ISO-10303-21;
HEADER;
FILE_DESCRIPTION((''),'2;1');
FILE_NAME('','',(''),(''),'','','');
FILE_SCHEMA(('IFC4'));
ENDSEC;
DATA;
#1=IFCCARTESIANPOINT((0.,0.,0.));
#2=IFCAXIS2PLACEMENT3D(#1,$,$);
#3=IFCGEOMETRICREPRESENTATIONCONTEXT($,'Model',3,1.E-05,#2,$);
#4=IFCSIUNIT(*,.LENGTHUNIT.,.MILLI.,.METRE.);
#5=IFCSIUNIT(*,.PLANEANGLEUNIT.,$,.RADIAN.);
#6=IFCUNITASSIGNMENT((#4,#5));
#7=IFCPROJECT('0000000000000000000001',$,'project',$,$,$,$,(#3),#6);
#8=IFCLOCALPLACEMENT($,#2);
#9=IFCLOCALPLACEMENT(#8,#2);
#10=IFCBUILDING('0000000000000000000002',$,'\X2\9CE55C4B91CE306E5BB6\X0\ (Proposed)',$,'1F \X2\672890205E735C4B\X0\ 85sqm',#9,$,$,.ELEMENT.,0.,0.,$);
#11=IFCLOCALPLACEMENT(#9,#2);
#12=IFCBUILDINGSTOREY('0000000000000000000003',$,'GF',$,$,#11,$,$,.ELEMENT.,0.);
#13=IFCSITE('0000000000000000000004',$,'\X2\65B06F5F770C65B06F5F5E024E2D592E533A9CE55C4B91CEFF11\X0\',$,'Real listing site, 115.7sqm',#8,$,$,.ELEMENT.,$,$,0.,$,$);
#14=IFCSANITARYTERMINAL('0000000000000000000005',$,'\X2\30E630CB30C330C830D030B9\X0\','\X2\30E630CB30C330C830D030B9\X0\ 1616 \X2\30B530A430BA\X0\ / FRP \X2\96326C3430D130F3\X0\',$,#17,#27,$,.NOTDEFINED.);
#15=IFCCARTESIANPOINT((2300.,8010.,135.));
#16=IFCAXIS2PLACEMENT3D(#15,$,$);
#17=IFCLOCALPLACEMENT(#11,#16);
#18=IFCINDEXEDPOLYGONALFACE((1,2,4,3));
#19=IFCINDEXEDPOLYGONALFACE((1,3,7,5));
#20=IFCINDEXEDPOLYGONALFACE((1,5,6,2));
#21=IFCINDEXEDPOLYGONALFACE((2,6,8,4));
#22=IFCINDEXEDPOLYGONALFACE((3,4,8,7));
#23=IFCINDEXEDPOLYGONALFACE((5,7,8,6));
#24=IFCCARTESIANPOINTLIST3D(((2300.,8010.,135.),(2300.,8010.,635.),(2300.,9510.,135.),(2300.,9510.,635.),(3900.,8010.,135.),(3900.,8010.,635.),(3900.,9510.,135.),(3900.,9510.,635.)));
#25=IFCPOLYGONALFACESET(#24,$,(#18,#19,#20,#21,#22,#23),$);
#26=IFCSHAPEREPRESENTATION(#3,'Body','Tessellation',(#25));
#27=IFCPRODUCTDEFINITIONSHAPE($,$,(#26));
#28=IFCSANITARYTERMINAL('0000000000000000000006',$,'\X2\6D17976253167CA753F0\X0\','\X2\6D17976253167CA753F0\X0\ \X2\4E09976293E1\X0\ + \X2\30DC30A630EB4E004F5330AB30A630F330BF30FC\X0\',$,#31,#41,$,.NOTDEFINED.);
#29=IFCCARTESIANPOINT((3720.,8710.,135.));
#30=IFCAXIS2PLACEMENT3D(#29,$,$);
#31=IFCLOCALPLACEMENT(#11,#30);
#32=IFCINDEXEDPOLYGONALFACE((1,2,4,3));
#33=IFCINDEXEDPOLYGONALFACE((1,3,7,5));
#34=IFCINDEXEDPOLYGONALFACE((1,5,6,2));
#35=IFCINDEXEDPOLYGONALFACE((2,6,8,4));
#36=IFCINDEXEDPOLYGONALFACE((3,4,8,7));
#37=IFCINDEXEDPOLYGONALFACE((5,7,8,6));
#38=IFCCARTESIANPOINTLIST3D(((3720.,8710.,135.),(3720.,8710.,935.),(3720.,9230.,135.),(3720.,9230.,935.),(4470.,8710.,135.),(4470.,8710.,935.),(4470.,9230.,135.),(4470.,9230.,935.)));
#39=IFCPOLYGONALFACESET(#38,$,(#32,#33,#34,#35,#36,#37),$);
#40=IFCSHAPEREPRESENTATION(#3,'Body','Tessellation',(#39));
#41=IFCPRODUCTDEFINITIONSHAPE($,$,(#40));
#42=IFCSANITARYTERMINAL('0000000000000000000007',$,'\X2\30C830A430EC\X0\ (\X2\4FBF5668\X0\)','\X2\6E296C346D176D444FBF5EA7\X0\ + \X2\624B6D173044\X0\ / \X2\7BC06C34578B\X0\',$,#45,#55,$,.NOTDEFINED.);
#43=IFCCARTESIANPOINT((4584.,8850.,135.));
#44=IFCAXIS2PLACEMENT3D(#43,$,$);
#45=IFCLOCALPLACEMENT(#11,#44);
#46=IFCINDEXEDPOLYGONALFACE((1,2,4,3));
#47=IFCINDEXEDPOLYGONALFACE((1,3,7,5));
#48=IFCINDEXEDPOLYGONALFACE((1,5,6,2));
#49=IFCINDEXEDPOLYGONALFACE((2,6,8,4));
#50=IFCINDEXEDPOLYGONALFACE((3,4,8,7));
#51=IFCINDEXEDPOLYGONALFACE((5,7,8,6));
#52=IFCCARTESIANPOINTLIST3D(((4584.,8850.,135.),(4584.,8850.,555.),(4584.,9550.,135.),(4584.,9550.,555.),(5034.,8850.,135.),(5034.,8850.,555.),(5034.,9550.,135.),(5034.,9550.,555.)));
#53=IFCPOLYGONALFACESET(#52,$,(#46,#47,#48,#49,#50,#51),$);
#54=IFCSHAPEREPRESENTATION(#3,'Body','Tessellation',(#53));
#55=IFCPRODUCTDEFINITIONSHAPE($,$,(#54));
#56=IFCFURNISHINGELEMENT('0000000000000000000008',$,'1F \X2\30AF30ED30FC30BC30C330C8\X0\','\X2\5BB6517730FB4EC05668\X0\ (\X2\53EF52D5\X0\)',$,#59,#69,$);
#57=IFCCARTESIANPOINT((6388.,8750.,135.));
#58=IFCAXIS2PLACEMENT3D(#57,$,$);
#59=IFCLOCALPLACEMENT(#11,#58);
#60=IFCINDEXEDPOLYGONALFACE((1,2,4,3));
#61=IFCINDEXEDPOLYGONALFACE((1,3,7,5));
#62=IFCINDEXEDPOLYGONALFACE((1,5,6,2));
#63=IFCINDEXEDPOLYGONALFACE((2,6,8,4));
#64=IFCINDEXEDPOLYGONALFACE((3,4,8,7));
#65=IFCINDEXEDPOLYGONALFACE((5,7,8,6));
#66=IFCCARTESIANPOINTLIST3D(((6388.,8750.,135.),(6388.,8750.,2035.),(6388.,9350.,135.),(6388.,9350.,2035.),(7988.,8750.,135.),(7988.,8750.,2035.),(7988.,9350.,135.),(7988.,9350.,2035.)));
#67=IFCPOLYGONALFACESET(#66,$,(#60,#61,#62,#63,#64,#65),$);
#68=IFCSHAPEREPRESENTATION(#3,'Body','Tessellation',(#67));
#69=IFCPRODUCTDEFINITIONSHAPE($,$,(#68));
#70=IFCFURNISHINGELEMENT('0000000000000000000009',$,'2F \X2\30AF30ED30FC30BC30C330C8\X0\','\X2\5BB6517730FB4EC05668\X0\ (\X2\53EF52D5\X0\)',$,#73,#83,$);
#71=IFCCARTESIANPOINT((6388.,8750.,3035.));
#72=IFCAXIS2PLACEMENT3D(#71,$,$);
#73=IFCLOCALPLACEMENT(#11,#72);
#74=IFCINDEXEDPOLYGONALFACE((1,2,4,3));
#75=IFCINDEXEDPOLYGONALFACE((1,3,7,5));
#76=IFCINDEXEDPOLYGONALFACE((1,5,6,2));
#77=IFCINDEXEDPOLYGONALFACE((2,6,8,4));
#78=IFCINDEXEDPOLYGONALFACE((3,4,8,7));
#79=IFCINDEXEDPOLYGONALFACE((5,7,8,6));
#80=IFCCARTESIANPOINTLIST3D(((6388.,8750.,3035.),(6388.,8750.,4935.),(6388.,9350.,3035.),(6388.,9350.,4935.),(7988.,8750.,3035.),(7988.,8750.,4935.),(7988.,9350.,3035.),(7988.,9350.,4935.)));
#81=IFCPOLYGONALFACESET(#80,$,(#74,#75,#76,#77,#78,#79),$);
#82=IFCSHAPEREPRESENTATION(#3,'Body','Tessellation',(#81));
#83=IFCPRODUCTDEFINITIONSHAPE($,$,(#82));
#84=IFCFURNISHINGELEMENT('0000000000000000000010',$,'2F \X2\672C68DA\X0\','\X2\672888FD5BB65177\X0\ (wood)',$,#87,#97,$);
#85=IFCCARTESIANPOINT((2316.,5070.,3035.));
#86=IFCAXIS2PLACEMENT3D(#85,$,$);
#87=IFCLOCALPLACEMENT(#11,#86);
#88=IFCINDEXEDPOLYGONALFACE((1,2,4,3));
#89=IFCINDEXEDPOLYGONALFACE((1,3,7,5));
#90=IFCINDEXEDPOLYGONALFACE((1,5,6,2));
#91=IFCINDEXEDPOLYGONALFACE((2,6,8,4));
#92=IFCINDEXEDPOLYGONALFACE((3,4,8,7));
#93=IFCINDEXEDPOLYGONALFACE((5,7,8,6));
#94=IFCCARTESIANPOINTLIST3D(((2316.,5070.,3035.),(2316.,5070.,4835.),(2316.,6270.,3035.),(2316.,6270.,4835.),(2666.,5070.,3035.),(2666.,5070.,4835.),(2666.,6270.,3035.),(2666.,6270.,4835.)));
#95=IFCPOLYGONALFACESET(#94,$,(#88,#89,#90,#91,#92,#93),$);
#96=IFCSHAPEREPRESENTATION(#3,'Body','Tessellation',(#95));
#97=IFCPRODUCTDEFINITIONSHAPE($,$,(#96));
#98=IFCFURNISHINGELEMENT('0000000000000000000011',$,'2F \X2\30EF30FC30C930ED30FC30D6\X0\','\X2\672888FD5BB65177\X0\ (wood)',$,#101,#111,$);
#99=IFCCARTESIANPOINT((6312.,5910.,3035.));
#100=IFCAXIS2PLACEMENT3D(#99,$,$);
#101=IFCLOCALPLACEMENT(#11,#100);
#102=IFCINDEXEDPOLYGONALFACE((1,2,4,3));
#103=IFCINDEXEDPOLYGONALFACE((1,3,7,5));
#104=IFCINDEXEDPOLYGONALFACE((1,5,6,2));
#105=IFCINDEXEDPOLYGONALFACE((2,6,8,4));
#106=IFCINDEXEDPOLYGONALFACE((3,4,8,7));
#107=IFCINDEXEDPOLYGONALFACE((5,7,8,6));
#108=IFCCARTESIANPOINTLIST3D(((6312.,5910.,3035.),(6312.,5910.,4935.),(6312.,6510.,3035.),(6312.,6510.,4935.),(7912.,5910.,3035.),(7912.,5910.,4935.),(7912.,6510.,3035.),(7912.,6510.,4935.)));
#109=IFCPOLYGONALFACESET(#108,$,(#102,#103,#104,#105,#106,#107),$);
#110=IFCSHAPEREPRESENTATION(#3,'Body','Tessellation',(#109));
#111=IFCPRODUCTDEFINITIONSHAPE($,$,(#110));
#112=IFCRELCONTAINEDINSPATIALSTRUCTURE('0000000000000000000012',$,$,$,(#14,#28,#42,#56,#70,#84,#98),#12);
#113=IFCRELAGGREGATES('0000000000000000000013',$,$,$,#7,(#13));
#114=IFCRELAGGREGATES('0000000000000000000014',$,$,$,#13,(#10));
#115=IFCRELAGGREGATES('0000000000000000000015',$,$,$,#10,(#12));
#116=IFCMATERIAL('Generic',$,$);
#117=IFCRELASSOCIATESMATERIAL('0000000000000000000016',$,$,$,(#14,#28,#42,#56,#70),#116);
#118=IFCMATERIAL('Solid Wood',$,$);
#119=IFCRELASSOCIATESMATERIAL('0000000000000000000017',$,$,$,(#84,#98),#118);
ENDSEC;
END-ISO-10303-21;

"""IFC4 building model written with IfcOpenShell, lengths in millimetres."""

from ifc_helpers import new_model, si_unit, frame, frame_2d, origin, place, context, project, spatial, rectangle, extrude, material, element, save


model = new_model("IFC4")

# Units and contexts
model_context = context("Model", 3, precision=1e-05, world=origin())
ifc_project = project(units=[si_unit("LENGTHUNIT", "METRE", prefix="MILLI"), si_unit("PLANEANGLEUNIT", "RADIAN")], contexts=[model_context])

# Site, building, storey
site_placement = place(None, origin())
site = spatial("IfcSite", under=ifc_project, at=site_placement, Name="新潟県新潟市中央区鳥屋野１", ObjectType="Real listing site, 115.7sqm", CompositionType="ELEMENT", RefElevation=0.0)
building_placement = place(site_placement, origin())
building = spatial("IfcBuilding", under=site, at=building_placement, Name="鳥屋野の家 (Proposed)", ObjectType="1F 木造平屋 85sqm", CompositionType="ELEMENT", ElevationOfRefHeight=0.0, ElevationOfTerrain=0.0)
storey_placement = place(building_placement, origin())
storey = spatial("IfcBuildingStorey", under=building, at=storey_placement, Name="GF", CompositionType="ELEMENT", Elevation=0.0)

# Shared definitions
ifc_material_1 = material(Name="Solid Wood")

# Shared definitions
ifc_material_2 = material(Name="Generic")

# Sanitary terminals
sanitary_terminal_1_placement = place(storey_placement, frame((2300.0, 8010.0, 135.0)))
element("IfcSanitaryTerminal", 1, at=sanitary_terminal_1_placement, inside=storey, material=ifc_material_2, Name="ユニットバス", Description="ユニットバス 1616 サイズ / FRP 防水パン", PredefinedType="NOTDEFINED", context=model_context, shape_type="SweptSolid", body=[
    extrude(rectangle(XDim=1600.0, YDim=1500.0, at=frame_2d((800.0, 750.0))), frame((2300.0, 8010.0, 135.0)), (0.0, 0.0, 1.0), 500.0),
])
sanitary_terminal_2_placement = place(storey_placement, frame((3720.0, 8710.0, 135.0)))
element("IfcSanitaryTerminal", 2, at=sanitary_terminal_2_placement, inside=storey, material=ifc_material_2, Name="洗面化粧台", Description="洗面化粧台 三面鏡 + ボウル一体カウンター", PredefinedType="NOTDEFINED", context=model_context, shape_type="SweptSolid", body=[
    extrude(rectangle(XDim=750.0, YDim=520.0, at=frame_2d((375.0, 260.0))), frame((3720.0, 8710.0, 135.0)), (0.0, 0.0, 1.0), 800.0),
])
sanitary_terminal_3_placement = place(storey_placement, frame((4584.0, 8850.0, 135.0)))
element("IfcSanitaryTerminal", 3, at=sanitary_terminal_3_placement, inside=storey, material=ifc_material_2, Name="トイレ (便器)", Description="温水洗浄便座 + 手洗い / 節水型", PredefinedType="NOTDEFINED", context=model_context, shape_type="SweptSolid", body=[
    extrude(rectangle(XDim=450.0, YDim=700.0, at=frame_2d((225.0, 350.0))), frame((4584.0, 8850.0, 135.0)), (0.0, 0.0, 1.0), 420.0),
])

# Furnishing elements
furnishing_1_placement = place(storey_placement, frame((6388.0, 8750.0, 135.0)))
element("IfcFurnishingElement", 4, at=furnishing_1_placement, inside=storey, material=ifc_material_2, Name="1F クローゼット", Description="家具・什器 (可動)", context=model_context, shape_type="SweptSolid", body=[
    extrude(rectangle(XDim=1600.0, YDim=600.0, at=frame_2d((800.0, 300.0))), frame((6388.0, 8750.0, 135.0)), (0.0, 0.0, 1.0), 1900.0),
])
furnishing_2_placement = place(storey_placement, frame((6388.0, 8750.0, 3035.0)))
element("IfcFurnishingElement", 5, at=furnishing_2_placement, inside=storey, material=ifc_material_2, Name="2F クローゼット", Description="家具・什器 (可動)", context=model_context, shape_type="SweptSolid", body=[
    extrude(rectangle(XDim=1600.0, YDim=600.0, at=frame_2d((800.0, 300.0))), frame((6388.0, 8750.0, 3035.0)), (0.0, 0.0, 1.0), 1900.0),
])
furnishing_3_placement = place(storey_placement, frame((2316.0, 5070.0, 3035.0)))
element("IfcFurnishingElement", 6, at=furnishing_3_placement, inside=storey, material=ifc_material_1, Name="2F 本棚", Description="木製家具 (wood)", context=model_context, shape_type="SweptSolid", body=[
    extrude(rectangle(XDim=350.0, YDim=1200.0, at=frame_2d((175.0, 600.0))), frame((2316.0, 5070.0, 3035.0)), (0.0, 0.0, 1.0), 1800.0),
])
furnishing_4_placement = place(storey_placement, frame((6312.0, 5910.0, 3035.0)))
element("IfcFurnishingElement", 7, at=furnishing_4_placement, inside=storey, material=ifc_material_1, Name="2F ワードローブ", Description="木製家具 (wood)", context=model_context, shape_type="SweptSolid", body=[
    extrude(rectangle(XDim=1600.0, YDim=600.0, at=frame_2d((800.0, 300.0))), frame((6312.0, 5910.0, 3035.0)), (0.0, 0.0, 1.0), 1900.0),
])

save(model, "model.ifc")
